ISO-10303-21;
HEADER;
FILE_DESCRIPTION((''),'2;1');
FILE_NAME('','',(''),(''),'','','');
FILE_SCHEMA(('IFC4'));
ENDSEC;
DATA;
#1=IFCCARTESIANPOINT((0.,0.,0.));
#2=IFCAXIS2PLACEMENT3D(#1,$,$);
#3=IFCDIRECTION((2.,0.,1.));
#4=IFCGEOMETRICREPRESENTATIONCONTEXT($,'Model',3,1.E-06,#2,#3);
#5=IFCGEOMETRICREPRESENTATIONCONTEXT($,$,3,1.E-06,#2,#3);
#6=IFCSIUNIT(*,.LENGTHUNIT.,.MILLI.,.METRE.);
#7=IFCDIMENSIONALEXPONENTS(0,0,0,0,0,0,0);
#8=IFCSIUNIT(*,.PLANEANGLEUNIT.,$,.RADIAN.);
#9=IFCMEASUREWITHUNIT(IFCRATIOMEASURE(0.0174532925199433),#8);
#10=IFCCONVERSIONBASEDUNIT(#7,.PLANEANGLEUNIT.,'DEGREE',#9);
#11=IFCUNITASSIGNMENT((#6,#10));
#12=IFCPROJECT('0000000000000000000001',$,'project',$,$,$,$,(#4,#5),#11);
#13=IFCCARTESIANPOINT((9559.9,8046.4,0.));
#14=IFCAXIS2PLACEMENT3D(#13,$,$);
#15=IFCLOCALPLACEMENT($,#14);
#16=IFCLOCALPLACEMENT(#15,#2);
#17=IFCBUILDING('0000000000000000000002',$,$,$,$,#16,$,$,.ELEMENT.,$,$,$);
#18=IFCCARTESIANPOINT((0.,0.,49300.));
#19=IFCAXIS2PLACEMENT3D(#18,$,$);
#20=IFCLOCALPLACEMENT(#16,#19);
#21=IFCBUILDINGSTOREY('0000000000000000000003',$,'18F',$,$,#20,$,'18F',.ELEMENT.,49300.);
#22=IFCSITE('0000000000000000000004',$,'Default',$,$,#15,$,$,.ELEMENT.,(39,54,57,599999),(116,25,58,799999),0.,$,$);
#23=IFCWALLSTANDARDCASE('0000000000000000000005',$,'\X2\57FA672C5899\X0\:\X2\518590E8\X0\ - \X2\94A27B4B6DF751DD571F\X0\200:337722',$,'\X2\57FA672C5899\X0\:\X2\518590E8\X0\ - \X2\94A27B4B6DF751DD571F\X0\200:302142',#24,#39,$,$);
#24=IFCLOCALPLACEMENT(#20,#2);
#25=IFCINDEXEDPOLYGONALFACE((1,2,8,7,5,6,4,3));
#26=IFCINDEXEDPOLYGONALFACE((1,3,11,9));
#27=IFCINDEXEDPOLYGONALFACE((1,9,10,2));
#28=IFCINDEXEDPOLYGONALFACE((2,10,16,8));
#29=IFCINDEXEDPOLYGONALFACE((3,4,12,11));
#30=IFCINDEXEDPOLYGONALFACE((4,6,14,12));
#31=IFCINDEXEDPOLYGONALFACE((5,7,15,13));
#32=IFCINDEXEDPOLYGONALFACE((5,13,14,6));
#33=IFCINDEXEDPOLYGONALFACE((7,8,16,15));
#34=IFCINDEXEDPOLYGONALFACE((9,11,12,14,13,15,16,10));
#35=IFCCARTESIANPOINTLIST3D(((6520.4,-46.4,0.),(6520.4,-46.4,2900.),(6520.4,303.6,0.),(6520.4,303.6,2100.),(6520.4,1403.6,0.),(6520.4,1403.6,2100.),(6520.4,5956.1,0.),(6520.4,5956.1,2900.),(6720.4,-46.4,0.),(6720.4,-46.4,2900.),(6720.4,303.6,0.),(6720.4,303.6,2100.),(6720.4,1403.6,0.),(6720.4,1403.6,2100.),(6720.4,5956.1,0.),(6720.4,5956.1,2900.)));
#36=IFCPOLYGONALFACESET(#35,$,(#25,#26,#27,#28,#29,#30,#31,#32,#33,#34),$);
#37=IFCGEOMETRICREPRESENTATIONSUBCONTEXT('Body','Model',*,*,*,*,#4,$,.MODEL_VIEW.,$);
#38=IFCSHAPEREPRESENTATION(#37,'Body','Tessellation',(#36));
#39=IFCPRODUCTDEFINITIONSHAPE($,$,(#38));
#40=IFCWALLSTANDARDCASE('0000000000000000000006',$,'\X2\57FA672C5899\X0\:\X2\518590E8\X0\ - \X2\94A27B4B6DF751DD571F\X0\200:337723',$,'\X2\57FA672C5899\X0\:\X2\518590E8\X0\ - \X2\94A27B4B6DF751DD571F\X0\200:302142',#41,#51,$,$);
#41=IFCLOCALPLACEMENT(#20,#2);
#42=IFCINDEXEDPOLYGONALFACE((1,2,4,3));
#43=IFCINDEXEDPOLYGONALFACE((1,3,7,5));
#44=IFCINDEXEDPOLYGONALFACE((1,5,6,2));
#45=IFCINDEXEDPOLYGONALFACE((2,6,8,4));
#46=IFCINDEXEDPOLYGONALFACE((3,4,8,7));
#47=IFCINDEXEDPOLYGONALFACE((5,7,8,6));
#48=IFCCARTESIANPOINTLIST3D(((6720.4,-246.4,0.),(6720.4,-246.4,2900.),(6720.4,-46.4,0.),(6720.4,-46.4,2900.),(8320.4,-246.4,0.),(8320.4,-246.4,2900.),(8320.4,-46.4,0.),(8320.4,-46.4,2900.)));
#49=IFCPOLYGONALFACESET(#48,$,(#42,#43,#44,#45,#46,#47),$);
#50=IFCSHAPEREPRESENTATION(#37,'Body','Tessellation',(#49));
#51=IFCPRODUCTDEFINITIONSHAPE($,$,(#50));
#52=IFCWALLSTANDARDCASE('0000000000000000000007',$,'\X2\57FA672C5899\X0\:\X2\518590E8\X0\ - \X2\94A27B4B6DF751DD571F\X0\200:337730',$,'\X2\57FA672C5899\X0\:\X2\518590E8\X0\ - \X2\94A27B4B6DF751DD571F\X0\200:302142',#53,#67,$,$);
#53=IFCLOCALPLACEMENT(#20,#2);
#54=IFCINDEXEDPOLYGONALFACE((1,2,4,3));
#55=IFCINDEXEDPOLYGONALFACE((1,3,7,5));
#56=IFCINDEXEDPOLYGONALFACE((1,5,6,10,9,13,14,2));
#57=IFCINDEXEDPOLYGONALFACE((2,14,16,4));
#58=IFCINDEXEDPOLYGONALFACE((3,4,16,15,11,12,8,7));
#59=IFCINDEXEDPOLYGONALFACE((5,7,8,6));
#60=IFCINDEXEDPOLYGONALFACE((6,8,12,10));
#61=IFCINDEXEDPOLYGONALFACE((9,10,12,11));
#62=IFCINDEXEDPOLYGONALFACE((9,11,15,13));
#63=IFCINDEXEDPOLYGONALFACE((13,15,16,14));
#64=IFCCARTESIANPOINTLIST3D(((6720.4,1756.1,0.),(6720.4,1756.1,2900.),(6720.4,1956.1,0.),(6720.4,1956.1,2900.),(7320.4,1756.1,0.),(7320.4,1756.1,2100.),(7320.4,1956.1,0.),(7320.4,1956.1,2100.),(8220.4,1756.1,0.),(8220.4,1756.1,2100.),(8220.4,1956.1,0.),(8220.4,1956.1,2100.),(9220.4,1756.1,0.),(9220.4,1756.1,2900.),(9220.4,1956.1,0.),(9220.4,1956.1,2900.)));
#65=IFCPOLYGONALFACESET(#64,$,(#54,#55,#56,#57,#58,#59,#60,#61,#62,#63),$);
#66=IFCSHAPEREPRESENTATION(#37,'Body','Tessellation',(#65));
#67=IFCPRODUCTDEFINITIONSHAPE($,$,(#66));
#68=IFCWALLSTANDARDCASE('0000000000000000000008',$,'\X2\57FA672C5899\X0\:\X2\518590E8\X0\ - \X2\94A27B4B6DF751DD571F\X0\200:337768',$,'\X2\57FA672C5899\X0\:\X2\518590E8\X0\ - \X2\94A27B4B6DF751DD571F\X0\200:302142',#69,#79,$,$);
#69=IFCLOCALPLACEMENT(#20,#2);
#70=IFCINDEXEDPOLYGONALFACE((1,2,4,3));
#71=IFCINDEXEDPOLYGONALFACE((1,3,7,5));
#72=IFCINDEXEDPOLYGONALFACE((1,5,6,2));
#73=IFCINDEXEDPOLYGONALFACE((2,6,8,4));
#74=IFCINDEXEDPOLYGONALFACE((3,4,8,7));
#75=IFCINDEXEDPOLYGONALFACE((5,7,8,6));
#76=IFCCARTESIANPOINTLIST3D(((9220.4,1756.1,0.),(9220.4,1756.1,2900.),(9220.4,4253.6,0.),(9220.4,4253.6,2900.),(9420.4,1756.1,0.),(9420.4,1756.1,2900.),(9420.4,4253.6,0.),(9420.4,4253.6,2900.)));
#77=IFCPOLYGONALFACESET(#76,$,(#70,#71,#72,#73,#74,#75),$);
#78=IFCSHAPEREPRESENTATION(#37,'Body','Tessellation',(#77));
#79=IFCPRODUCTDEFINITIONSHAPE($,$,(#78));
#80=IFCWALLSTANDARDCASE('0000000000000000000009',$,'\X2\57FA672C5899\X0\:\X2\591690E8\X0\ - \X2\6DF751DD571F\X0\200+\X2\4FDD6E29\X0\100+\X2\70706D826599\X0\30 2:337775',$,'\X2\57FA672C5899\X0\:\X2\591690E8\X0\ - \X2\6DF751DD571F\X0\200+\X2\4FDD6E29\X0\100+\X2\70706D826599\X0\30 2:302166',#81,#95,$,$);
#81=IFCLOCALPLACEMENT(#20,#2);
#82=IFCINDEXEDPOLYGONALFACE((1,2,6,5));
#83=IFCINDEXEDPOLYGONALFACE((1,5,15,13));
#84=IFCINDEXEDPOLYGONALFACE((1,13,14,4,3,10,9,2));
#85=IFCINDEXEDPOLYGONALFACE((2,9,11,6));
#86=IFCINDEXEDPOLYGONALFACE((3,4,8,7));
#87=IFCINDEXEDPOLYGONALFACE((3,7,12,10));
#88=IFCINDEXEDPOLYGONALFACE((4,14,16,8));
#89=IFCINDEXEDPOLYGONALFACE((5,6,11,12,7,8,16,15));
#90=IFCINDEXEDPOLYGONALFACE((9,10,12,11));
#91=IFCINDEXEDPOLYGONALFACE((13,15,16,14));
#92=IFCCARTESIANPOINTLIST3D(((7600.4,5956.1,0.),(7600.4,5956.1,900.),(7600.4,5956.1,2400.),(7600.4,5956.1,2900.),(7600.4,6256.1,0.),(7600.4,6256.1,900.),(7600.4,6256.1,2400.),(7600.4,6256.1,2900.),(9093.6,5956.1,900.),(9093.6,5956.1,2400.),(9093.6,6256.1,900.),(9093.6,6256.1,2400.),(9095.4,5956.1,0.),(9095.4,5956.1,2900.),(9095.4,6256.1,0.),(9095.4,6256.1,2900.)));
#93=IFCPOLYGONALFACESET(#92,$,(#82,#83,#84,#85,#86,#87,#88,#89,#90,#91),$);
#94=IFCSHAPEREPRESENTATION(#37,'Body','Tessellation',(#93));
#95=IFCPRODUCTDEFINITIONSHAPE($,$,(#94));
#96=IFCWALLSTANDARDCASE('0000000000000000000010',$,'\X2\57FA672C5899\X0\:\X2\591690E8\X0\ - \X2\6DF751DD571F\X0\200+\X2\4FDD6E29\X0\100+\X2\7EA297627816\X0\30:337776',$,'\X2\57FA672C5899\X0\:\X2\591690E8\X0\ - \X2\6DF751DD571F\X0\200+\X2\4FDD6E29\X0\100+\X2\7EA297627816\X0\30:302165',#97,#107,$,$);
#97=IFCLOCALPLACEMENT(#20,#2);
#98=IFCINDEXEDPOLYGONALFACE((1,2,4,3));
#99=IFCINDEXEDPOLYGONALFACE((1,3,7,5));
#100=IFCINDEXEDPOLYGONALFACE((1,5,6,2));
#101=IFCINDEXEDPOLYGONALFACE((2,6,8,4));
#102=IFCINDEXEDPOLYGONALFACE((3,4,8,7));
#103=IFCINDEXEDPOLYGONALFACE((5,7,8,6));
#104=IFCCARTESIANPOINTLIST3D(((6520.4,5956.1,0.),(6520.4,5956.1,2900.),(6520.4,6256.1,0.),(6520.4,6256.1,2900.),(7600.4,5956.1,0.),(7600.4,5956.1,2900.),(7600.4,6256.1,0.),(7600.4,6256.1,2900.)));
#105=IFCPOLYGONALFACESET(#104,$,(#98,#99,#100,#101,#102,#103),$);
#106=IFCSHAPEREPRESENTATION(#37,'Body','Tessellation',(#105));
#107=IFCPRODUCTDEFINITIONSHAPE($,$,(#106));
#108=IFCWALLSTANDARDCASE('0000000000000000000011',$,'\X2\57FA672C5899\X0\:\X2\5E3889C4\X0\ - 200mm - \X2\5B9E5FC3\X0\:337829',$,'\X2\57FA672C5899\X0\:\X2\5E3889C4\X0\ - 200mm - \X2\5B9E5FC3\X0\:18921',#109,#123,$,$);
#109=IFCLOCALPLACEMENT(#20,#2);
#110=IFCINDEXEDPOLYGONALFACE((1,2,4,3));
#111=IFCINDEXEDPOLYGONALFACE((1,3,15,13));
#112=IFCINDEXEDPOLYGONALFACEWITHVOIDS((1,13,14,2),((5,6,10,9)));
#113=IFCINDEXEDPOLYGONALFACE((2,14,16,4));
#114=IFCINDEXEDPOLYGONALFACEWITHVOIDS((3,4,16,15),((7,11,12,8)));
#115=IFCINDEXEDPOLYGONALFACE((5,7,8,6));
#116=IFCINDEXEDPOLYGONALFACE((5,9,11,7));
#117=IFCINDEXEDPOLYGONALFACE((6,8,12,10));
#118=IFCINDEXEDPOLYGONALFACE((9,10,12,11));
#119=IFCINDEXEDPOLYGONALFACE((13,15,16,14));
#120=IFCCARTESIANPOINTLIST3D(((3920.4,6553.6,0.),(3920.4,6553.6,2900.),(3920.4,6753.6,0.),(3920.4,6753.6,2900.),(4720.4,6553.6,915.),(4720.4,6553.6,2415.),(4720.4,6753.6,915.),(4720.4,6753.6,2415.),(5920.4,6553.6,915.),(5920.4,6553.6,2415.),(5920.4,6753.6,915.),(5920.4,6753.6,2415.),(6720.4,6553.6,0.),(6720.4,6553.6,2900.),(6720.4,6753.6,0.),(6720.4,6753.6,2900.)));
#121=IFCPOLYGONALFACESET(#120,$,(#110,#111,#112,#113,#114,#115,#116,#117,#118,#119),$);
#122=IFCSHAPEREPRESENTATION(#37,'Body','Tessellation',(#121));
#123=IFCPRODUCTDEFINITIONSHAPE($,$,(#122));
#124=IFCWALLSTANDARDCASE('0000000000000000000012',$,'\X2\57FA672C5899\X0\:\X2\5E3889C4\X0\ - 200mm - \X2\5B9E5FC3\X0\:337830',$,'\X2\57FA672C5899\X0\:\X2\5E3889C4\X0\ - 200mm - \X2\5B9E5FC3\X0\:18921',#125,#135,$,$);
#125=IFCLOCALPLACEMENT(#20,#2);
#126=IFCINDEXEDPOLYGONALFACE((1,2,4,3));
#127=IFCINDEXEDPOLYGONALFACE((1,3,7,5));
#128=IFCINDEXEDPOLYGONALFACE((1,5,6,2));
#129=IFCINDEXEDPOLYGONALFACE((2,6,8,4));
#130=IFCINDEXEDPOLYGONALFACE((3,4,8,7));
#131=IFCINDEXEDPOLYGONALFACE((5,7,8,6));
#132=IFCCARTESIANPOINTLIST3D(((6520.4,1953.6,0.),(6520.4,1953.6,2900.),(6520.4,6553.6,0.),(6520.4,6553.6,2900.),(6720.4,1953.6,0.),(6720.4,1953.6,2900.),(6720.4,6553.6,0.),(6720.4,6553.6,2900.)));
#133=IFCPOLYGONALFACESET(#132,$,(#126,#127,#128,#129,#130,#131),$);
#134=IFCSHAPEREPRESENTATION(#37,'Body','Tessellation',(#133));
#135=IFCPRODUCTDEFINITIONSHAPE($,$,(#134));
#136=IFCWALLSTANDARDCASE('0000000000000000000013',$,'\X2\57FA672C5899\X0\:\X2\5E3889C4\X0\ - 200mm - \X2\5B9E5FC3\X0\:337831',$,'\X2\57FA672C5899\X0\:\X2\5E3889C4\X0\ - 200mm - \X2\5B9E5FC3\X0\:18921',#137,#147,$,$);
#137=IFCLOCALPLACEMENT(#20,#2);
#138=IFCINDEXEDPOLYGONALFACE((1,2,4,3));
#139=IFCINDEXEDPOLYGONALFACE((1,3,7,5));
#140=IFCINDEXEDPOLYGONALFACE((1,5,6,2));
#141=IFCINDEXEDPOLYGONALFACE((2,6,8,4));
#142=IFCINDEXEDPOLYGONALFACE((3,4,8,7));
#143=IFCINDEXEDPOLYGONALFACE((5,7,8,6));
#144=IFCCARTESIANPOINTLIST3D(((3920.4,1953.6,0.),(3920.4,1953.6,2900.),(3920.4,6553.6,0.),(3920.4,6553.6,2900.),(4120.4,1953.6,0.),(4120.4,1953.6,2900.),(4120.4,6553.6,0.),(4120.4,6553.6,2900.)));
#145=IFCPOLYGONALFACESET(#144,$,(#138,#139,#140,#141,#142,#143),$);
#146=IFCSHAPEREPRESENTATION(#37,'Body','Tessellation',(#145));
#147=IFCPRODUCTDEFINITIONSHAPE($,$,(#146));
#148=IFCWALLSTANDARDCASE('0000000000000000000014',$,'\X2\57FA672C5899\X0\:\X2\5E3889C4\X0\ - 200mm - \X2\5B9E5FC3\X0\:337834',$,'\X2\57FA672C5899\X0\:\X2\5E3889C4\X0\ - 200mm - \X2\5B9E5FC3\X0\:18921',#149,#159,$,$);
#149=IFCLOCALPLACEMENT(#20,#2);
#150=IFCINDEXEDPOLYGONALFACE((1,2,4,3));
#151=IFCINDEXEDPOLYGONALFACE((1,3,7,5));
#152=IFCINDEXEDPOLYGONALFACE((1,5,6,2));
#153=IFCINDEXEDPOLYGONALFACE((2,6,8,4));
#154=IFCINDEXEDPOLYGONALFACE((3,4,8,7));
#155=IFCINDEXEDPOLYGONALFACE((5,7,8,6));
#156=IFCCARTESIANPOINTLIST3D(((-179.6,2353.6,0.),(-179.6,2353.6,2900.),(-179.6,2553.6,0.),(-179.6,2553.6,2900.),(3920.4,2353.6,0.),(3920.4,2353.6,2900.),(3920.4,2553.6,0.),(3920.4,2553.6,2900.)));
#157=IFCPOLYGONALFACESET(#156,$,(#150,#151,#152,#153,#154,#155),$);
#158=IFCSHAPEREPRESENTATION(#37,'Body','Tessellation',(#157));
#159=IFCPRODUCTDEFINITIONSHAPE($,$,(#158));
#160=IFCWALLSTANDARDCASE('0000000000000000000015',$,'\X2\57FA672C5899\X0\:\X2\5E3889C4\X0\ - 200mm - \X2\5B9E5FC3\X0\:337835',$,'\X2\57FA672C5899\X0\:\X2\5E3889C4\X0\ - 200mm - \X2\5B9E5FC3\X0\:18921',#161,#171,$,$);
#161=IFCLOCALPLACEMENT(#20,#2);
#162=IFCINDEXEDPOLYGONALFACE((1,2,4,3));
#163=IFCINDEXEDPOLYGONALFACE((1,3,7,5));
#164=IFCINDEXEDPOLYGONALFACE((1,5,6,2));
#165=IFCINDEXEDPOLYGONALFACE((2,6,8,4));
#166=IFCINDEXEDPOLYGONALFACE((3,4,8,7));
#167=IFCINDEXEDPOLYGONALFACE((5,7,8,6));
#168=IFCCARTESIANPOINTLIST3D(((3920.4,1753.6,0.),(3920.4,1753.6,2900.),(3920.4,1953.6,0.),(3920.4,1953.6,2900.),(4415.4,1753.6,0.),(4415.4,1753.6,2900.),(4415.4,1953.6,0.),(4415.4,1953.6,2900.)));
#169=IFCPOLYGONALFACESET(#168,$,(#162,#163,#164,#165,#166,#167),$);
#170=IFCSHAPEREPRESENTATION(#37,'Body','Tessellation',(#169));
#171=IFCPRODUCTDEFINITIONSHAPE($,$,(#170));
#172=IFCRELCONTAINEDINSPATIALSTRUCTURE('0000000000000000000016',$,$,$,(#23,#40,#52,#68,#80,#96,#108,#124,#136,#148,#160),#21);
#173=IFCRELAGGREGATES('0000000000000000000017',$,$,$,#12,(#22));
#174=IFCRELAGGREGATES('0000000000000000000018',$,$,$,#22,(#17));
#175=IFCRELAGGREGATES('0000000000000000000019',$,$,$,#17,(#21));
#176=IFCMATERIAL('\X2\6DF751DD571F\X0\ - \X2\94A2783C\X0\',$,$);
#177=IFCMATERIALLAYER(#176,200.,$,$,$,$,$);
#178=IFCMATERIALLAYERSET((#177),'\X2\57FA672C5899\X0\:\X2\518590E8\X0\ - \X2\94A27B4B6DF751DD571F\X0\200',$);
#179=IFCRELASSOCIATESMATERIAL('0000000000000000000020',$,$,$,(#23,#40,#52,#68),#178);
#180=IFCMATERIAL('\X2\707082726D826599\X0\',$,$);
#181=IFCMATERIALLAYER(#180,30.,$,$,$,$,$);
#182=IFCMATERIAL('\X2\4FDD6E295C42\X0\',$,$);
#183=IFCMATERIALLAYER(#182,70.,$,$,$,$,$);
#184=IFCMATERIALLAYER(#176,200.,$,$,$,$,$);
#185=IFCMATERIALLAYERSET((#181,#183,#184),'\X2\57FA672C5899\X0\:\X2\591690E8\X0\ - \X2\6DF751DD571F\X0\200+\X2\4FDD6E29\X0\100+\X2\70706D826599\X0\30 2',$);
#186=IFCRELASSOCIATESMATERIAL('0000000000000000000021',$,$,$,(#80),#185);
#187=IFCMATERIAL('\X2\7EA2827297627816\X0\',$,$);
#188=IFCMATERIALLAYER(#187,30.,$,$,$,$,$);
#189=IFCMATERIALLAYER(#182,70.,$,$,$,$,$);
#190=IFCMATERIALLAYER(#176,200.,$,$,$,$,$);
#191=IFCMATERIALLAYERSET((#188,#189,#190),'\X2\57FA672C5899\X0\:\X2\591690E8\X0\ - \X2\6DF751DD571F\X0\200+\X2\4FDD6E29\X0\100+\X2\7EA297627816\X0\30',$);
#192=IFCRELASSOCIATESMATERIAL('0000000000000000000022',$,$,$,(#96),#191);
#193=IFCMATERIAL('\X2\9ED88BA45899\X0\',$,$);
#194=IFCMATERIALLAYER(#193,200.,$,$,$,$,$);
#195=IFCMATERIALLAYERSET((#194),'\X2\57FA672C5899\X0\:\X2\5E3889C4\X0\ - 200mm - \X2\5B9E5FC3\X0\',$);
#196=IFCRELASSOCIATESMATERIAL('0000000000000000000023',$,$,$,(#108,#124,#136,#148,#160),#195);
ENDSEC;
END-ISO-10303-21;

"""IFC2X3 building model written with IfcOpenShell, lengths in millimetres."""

from ifc_helpers import new_model, entity, si_unit, converted_unit, direction, frame, frame_2d, origin, place, context, subcontext, project, spatial, rectangle, extrude, material, layer, layer_set, layer_usage, element, save


model = new_model("IFC2X3")

# Units and contexts
model_context = context("Model", 3, precision=1e-06, world=origin(), true_north=direction((2.0, 0.0, 1.0)))
context_of_model = context(None, 3, precision=1e-06, world=origin(), true_north=direction((2.0, 0.0, 1.0)))
body_context = subcontext(model_context, "Body", "Model", "MODEL_VIEW")
ifc_project = project(units=[si_unit("LENGTHUNIT", "METRE", prefix="MILLI"), converted_unit("PLANEANGLEUNIT", "DEGREE", entity("IfcRatioMeasure", 0.0174532925199433), si_unit("PLANEANGLEUNIT", "RADIAN"), dimensions=[0, 0, 0, 0, 0, 0, 0])], contexts=[model_context, context_of_model])

# Site, building, storey
site_placement = place(None, frame((9559.9, 8046.4, 0.0)))
site = spatial("IfcSite", under=ifc_project, at=site_placement, Name="Default", CompositionType="ELEMENT", RefLatitude=(39, 54, 57, 599999), RefLongitude=(116, 25, 58, 799999), RefElevation=0.0)
building_placement = place(site_placement, origin())
building = spatial("IfcBuilding", under=site, at=building_placement, CompositionType="ELEMENT")
storey_placement = place(building_placement, frame((0.0, 0.0, 49300.0)))
storey = spatial("IfcBuildingStorey", under=building, at=storey_placement, Name="18F", LongName="18F", CompositionType="ELEMENT", Elevation=49300.0)

# Wall, opening
ifc_material_1 = material(Name="混凝土 - 钢砼")
ifc_layer_1 = layer(ifc_material_1, 200.0)
ifc_layer_set_1 = layer_set([ifc_layer_1], Name="基本墙:内部 - 钢筋混凝土200")
ifc_layer_usage_1 = layer_usage(ifc_layer_set_1, "AXIS2", "POSITIVE", -100.0)
wall_1_placement = place(storey_placement, frame((6620.4, 5956.1, 0.0), z_axis=(0.0, 0.0, 1.0), x_axis=(0.0, -1.0, 0.0)))
wall_1 = element("IfcWallStandardCase", 1, at=wall_1_placement, inside=storey, material=ifc_layer_usage_1, Name="基本墙:内部 - 钢筋混凝土200:337722", ObjectType="基本墙:内部 - 钢筋混凝土200:302142", context=body_context, shape_type="SweptSolid", body=[
    extrude(rectangle(XDim=6002.5, YDim=200.0, at=frame_2d((3001.2, 0.0), x_axis=(-1.0, 0.0))), origin(), (0.0, 0.0, 1.0), 2900.0),
])
opening_1_placement = place(wall_1_placement, frame((5652.5, 100.0, 0.0)))
element("IfcOpeningElement", 2, at=opening_1_placement, cuts=wall_1, ObjectType="Opening", context=body_context, shape_type="SweptSolid", body=[
    extrude(rectangle(XDim=2100.0, YDim=1100.0, at=frame_2d((1050.0, 550.0), x_axis=(1.0, 0.0))), frame((0.0, 0.0, 0.0), z_axis=(0.0, -1.0, 0.0), x_axis=(0.0, 0.0, 1.0)), (0.0, 0.0, 1.0), 200.0),
])

# Wall
ifc_layer_usage_2 = layer_usage(ifc_layer_set_1, "AXIS2", "POSITIVE", -100.0)
wall_2_placement = place(storey_placement, frame((6720.4, -146.4, 0.0)))
element("IfcWallStandardCase", 3, at=wall_2_placement, inside=storey, material=ifc_layer_usage_2, Name="基本墙:内部 - 钢筋混凝土200:337723", ObjectType="基本墙:内部 - 钢筋混凝土200:302142", context=body_context, shape_type="SweptSolid", body=[
    extrude(rectangle(XDim=1600.0, YDim=200.0, at=frame_2d((800.0, 0.0), x_axis=(-1.0, 0.0))), origin(), (0.0, 0.0, 1.0), 2900.0),
])

# Wall, opening
ifc_layer_usage_3 = layer_usage(ifc_layer_set_1, "AXIS2", "POSITIVE", -100.0)
wall_3_placement = place(storey_placement, frame((9220.4, 1856.1, 0.0), z_axis=(0.0, 0.0, 1.0), x_axis=(-1.0, 0.0, 0.0)))
wall_3 = element("IfcWallStandardCase", 4, at=wall_3_placement, inside=storey, material=ifc_layer_usage_3, Name="基本墙:内部 - 钢筋混凝土200:337730", ObjectType="基本墙:内部 - 钢筋混凝土200:302142", context=body_context, shape_type="SweptSolid", body=[
    extrude(rectangle(XDim=2500.0, YDim=200.0, at=frame_2d((1250.0, 0.0), x_axis=(-1.0, 0.0))), origin(), (0.0, 0.0, 1.0), 2900.0),
])
opening_2_placement = place(wall_3_placement, frame((1900.0, 100.0, 0.0)))
element("IfcOpeningElement", 5, at=opening_2_placement, cuts=wall_3, ObjectType="Opening", context=body_context, shape_type="SweptSolid", body=[
    extrude(rectangle(XDim=2100.0, YDim=900.0, at=frame_2d((1050.0, 450.0), x_axis=(1.0, 0.0))), frame((0.0, 0.0, 0.0), z_axis=(0.0, -1.0, 0.0), x_axis=(0.0, 0.0, 1.0)), (0.0, 0.0, 1.0), 200.0),
])

# Wall
ifc_layer_usage_4 = layer_usage(ifc_layer_set_1, "AXIS2", "POSITIVE", -100.0)
wall_4_placement = place(storey_placement, frame((9320.4, 4253.6, 0.0), z_axis=(0.0, 0.0, 1.0), x_axis=(0.0, -1.0, 0.0)))
element("IfcWallStandardCase", 6, at=wall_4_placement, inside=storey, material=ifc_layer_usage_4, Name="基本墙:内部 - 钢筋混凝土200:337768", ObjectType="基本墙:内部 - 钢筋混凝土200:302142", context=body_context, shape_type="SweptSolid", body=[
    extrude(rectangle(XDim=2497.5, YDim=200.0, at=frame_2d((1248.8, 0.0), x_axis=(-1.0, 0.0))), origin(), (0.0, 0.0, 1.0), 2900.0),
])

# Wall, opening
ifc_material_2 = material(Name="灰色涂料")
ifc_layer_2 = layer(ifc_material_2, 30.0)
ifc_material_3 = material(Name="保温层")
ifc_layer_3 = layer(ifc_material_3, 70.0)
ifc_layer_4 = layer(ifc_material_1, 200.0)
ifc_layer_set_2 = layer_set([ifc_layer_2, ifc_layer_3, ifc_layer_4], Name="基本墙:外部 - 混凝土200+保温100+灰涂料30 2")
ifc_layer_usage_5 = layer_usage(ifc_layer_set_2, "AXIS2", "POSITIVE", -150.0)
wall_5_placement = place(storey_placement, frame((9095.4, 6106.1, 0.0), z_axis=(0.0, 0.0, 1.0), x_axis=(-1.0, 0.0, 0.0)))
wall_5 = element("IfcWallStandardCase", 7, at=wall_5_placement, inside=storey, material=ifc_layer_usage_5, Name="基本墙:外部 - 混凝土200+保温100+灰涂料30 2:337775", ObjectType="基本墙:外部 - 混凝土200+保温100+灰涂料30 2:302166", context=body_context, shape_type="SweptSolid", body=[
    extrude(rectangle(XDim=1495.0, YDim=300.0, at=frame_2d((747.5, 0.0), x_axis=(-1.0, 0.0))), origin(), (0.0, 0.0, 1.0), 2900.0),
])
opening_3_placement = place(wall_5_placement, frame((1501.7, 150.0, 900.0)))
element("IfcOpeningElement", 8, at=opening_3_placement, cuts=wall_5, ObjectType="Opening", context=body_context, shape_type="SweptSolid", body=[
    extrude(rectangle(XDim=1500.0, YDim=1500.0, at=frame_2d((750.0, 750.0), x_axis=(1.0, 0.0))), frame((0.0, 0.0, 0.0), z_axis=(0.0, -1.0, 0.0), x_axis=(0.0, 0.0, 1.0)), (0.0, 0.0, 1.0), 300.0),
])

# Wall
ifc_material_4 = material(Name="红色面砖")
ifc_layer_5 = layer(ifc_material_4, 30.0)
ifc_layer_6 = layer(ifc_material_3, 70.0)
ifc_layer_7 = layer(ifc_material_1, 200.0)
ifc_layer_set_3 = layer_set([ifc_layer_5, ifc_layer_6, ifc_layer_7], Name="基本墙:外部 - 混凝土200+保温100+红面砖30")
ifc_layer_usage_6 = layer_usage(ifc_layer_set_3, "AXIS2", "POSITIVE", -150.0)
wall_6_placement = place(storey_placement, frame((7600.4, 6106.1, 0.0), z_axis=(0.0, 0.0, 1.0), x_axis=(-1.0, 0.0, 0.0)))
element("IfcWallStandardCase", 9, at=wall_6_placement, inside=storey, material=ifc_layer_usage_6, Name="基本墙:外部 - 混凝土200+保温100+红面砖30:337776", ObjectType="基本墙:外部 - 混凝土200+保温100+红面砖30:302165", context=body_context, shape_type="SweptSolid", body=[
    extrude(rectangle(XDim=1080.0, YDim=300.0, at=frame_2d((540.0, 0.0), x_axis=(-1.0, 0.0))), origin(), (0.0, 0.0, 1.0), 2900.0),
])

# Wall, opening
ifc_material_5 = material(Name="默认墙")
ifc_layer_8 = layer(ifc_material_5, 200.0)
ifc_layer_set_4 = layer_set([ifc_layer_8], Name="基本墙:常规 - 200mm - 实心")
ifc_layer_usage_7 = layer_usage(ifc_layer_set_4, "AXIS2", "NEGATIVE", 100.0)
wall_7_placement = place(storey_placement, frame((3920.4, 6653.6, 0.0)))
wall_7 = element("IfcWallStandardCase", 10, at=wall_7_placement, inside=storey, material=ifc_layer_usage_7, Name="基本墙:常规 - 200mm - 实心:337829", ObjectType="基本墙:常规 - 200mm - 实心:18921", context=body_context, shape_type="SweptSolid", body=[
    extrude(rectangle(XDim=2800.0, YDim=200.0, at=frame_2d((1400.0, 0.0), x_axis=(-1.0, 0.0))), origin(), (0.0, 0.0, 1.0), 2900.0),
])
opening_4_placement = place(wall_7_placement, frame((2000.0, 100.0, 915.0)))
element("IfcOpeningElement", 11, at=opening_4_placement, cuts=wall_7, ObjectType="Opening", context=body_context, shape_type="SweptSolid", body=[
    extrude(rectangle(XDim=1500.0, YDim=1200.0, at=frame_2d((750.0, 600.0), x_axis=(1.0, 0.0))), frame((0.0, 0.0, 0.0), z_axis=(0.0, -1.0, 0.0), x_axis=(0.0, 0.0, 1.0)), (0.0, 0.0, 1.0), 200.0),
])

# Walls
ifc_layer_usage_8 = layer_usage(ifc_layer_set_4, "AXIS2", "NEGATIVE", 100.0)
wall_8_placement = place(storey_placement, frame((6620.4, 6553.6, 0.0), z_axis=(0.0, 0.0, 1.0), x_axis=(0.0, -1.0, 0.0)))
element("IfcWallStandardCase", 12, at=wall_8_placement, inside=storey, material=ifc_layer_usage_8, Name="基本墙:常规 - 200mm - 实心:337830", ObjectType="基本墙:常规 - 200mm - 实心:18921", context=body_context, shape_type="SweptSolid", body=[
    extrude(rectangle(XDim=4600.0, YDim=200.0, at=frame_2d((2300.0, 0.0), x_axis=(-1.0, 0.0))), origin(), (0.0, 0.0, 1.0), 2900.0),
])
ifc_layer_usage_9 = layer_usage(ifc_layer_set_4, "AXIS2", "NEGATIVE", 100.0)
wall_9_placement = place(storey_placement, frame((4020.4, 6553.6, 0.0), z_axis=(0.0, 0.0, 1.0), x_axis=(0.0, -1.0, 0.0)))
element("IfcWallStandardCase", 13, at=wall_9_placement, inside=storey, material=ifc_layer_usage_9, Name="基本墙:常规 - 200mm - 实心:337831", ObjectType="基本墙:常规 - 200mm - 实心:18921", context=body_context, shape_type="SweptSolid", body=[
    extrude(rectangle(XDim=4600.0, YDim=200.0, at=frame_2d((2300.0, 0.0), x_axis=(-1.0, 0.0))), origin(), (0.0, 0.0, 1.0), 2900.0),
])
ifc_layer_usage_10 = layer_usage(ifc_layer_set_4, "AXIS2", "NEGATIVE", 100.0)
wall_10_placement = place(storey_placement, frame((3920.4, 2453.6, 0.0), z_axis=(0.0, 0.0, 1.0), x_axis=(-1.0, 0.0, 0.0)))
element("IfcWallStandardCase", 14, at=wall_10_placement, inside=storey, material=ifc_layer_usage_10, Name="基本墙:常规 - 200mm - 实心:337834", ObjectType="基本墙:常规 - 200mm - 实心:18921", context=body_context, shape_type="SweptSolid", body=[
    extrude(rectangle(XDim=4100.0, YDim=200.0, at=frame_2d((2050.0, 0.0), x_axis=(-1.0, 0.0))), origin(), (0.0, 0.0, 1.0), 2900.0),
])
ifc_layer_usage_11 = layer_usage(ifc_layer_set_4, "AXIS2", "POSITIVE", -100.0)
wall_11_placement = place(storey_placement, frame((4415.4, 1853.6, 0.0), z_axis=(0.0, 0.0, 1.0), x_axis=(-1.0, 0.0, 0.0)))
element("IfcWallStandardCase", 15, at=wall_11_placement, inside=storey, material=ifc_layer_usage_11, Name="基本墙:常规 - 200mm - 实心:337835", ObjectType="基本墙:常规 - 200mm - 实心:18921", context=body_context, shape_type="SweptSolid", body=[
    extrude(rectangle(XDim=495.0, YDim=200.0, at=frame_2d((247.5, 0.0), x_axis=(-1.0, 0.0))), origin(), (0.0, 0.0, 1.0), 2900.0),
])

save(model, "model.ifc")
